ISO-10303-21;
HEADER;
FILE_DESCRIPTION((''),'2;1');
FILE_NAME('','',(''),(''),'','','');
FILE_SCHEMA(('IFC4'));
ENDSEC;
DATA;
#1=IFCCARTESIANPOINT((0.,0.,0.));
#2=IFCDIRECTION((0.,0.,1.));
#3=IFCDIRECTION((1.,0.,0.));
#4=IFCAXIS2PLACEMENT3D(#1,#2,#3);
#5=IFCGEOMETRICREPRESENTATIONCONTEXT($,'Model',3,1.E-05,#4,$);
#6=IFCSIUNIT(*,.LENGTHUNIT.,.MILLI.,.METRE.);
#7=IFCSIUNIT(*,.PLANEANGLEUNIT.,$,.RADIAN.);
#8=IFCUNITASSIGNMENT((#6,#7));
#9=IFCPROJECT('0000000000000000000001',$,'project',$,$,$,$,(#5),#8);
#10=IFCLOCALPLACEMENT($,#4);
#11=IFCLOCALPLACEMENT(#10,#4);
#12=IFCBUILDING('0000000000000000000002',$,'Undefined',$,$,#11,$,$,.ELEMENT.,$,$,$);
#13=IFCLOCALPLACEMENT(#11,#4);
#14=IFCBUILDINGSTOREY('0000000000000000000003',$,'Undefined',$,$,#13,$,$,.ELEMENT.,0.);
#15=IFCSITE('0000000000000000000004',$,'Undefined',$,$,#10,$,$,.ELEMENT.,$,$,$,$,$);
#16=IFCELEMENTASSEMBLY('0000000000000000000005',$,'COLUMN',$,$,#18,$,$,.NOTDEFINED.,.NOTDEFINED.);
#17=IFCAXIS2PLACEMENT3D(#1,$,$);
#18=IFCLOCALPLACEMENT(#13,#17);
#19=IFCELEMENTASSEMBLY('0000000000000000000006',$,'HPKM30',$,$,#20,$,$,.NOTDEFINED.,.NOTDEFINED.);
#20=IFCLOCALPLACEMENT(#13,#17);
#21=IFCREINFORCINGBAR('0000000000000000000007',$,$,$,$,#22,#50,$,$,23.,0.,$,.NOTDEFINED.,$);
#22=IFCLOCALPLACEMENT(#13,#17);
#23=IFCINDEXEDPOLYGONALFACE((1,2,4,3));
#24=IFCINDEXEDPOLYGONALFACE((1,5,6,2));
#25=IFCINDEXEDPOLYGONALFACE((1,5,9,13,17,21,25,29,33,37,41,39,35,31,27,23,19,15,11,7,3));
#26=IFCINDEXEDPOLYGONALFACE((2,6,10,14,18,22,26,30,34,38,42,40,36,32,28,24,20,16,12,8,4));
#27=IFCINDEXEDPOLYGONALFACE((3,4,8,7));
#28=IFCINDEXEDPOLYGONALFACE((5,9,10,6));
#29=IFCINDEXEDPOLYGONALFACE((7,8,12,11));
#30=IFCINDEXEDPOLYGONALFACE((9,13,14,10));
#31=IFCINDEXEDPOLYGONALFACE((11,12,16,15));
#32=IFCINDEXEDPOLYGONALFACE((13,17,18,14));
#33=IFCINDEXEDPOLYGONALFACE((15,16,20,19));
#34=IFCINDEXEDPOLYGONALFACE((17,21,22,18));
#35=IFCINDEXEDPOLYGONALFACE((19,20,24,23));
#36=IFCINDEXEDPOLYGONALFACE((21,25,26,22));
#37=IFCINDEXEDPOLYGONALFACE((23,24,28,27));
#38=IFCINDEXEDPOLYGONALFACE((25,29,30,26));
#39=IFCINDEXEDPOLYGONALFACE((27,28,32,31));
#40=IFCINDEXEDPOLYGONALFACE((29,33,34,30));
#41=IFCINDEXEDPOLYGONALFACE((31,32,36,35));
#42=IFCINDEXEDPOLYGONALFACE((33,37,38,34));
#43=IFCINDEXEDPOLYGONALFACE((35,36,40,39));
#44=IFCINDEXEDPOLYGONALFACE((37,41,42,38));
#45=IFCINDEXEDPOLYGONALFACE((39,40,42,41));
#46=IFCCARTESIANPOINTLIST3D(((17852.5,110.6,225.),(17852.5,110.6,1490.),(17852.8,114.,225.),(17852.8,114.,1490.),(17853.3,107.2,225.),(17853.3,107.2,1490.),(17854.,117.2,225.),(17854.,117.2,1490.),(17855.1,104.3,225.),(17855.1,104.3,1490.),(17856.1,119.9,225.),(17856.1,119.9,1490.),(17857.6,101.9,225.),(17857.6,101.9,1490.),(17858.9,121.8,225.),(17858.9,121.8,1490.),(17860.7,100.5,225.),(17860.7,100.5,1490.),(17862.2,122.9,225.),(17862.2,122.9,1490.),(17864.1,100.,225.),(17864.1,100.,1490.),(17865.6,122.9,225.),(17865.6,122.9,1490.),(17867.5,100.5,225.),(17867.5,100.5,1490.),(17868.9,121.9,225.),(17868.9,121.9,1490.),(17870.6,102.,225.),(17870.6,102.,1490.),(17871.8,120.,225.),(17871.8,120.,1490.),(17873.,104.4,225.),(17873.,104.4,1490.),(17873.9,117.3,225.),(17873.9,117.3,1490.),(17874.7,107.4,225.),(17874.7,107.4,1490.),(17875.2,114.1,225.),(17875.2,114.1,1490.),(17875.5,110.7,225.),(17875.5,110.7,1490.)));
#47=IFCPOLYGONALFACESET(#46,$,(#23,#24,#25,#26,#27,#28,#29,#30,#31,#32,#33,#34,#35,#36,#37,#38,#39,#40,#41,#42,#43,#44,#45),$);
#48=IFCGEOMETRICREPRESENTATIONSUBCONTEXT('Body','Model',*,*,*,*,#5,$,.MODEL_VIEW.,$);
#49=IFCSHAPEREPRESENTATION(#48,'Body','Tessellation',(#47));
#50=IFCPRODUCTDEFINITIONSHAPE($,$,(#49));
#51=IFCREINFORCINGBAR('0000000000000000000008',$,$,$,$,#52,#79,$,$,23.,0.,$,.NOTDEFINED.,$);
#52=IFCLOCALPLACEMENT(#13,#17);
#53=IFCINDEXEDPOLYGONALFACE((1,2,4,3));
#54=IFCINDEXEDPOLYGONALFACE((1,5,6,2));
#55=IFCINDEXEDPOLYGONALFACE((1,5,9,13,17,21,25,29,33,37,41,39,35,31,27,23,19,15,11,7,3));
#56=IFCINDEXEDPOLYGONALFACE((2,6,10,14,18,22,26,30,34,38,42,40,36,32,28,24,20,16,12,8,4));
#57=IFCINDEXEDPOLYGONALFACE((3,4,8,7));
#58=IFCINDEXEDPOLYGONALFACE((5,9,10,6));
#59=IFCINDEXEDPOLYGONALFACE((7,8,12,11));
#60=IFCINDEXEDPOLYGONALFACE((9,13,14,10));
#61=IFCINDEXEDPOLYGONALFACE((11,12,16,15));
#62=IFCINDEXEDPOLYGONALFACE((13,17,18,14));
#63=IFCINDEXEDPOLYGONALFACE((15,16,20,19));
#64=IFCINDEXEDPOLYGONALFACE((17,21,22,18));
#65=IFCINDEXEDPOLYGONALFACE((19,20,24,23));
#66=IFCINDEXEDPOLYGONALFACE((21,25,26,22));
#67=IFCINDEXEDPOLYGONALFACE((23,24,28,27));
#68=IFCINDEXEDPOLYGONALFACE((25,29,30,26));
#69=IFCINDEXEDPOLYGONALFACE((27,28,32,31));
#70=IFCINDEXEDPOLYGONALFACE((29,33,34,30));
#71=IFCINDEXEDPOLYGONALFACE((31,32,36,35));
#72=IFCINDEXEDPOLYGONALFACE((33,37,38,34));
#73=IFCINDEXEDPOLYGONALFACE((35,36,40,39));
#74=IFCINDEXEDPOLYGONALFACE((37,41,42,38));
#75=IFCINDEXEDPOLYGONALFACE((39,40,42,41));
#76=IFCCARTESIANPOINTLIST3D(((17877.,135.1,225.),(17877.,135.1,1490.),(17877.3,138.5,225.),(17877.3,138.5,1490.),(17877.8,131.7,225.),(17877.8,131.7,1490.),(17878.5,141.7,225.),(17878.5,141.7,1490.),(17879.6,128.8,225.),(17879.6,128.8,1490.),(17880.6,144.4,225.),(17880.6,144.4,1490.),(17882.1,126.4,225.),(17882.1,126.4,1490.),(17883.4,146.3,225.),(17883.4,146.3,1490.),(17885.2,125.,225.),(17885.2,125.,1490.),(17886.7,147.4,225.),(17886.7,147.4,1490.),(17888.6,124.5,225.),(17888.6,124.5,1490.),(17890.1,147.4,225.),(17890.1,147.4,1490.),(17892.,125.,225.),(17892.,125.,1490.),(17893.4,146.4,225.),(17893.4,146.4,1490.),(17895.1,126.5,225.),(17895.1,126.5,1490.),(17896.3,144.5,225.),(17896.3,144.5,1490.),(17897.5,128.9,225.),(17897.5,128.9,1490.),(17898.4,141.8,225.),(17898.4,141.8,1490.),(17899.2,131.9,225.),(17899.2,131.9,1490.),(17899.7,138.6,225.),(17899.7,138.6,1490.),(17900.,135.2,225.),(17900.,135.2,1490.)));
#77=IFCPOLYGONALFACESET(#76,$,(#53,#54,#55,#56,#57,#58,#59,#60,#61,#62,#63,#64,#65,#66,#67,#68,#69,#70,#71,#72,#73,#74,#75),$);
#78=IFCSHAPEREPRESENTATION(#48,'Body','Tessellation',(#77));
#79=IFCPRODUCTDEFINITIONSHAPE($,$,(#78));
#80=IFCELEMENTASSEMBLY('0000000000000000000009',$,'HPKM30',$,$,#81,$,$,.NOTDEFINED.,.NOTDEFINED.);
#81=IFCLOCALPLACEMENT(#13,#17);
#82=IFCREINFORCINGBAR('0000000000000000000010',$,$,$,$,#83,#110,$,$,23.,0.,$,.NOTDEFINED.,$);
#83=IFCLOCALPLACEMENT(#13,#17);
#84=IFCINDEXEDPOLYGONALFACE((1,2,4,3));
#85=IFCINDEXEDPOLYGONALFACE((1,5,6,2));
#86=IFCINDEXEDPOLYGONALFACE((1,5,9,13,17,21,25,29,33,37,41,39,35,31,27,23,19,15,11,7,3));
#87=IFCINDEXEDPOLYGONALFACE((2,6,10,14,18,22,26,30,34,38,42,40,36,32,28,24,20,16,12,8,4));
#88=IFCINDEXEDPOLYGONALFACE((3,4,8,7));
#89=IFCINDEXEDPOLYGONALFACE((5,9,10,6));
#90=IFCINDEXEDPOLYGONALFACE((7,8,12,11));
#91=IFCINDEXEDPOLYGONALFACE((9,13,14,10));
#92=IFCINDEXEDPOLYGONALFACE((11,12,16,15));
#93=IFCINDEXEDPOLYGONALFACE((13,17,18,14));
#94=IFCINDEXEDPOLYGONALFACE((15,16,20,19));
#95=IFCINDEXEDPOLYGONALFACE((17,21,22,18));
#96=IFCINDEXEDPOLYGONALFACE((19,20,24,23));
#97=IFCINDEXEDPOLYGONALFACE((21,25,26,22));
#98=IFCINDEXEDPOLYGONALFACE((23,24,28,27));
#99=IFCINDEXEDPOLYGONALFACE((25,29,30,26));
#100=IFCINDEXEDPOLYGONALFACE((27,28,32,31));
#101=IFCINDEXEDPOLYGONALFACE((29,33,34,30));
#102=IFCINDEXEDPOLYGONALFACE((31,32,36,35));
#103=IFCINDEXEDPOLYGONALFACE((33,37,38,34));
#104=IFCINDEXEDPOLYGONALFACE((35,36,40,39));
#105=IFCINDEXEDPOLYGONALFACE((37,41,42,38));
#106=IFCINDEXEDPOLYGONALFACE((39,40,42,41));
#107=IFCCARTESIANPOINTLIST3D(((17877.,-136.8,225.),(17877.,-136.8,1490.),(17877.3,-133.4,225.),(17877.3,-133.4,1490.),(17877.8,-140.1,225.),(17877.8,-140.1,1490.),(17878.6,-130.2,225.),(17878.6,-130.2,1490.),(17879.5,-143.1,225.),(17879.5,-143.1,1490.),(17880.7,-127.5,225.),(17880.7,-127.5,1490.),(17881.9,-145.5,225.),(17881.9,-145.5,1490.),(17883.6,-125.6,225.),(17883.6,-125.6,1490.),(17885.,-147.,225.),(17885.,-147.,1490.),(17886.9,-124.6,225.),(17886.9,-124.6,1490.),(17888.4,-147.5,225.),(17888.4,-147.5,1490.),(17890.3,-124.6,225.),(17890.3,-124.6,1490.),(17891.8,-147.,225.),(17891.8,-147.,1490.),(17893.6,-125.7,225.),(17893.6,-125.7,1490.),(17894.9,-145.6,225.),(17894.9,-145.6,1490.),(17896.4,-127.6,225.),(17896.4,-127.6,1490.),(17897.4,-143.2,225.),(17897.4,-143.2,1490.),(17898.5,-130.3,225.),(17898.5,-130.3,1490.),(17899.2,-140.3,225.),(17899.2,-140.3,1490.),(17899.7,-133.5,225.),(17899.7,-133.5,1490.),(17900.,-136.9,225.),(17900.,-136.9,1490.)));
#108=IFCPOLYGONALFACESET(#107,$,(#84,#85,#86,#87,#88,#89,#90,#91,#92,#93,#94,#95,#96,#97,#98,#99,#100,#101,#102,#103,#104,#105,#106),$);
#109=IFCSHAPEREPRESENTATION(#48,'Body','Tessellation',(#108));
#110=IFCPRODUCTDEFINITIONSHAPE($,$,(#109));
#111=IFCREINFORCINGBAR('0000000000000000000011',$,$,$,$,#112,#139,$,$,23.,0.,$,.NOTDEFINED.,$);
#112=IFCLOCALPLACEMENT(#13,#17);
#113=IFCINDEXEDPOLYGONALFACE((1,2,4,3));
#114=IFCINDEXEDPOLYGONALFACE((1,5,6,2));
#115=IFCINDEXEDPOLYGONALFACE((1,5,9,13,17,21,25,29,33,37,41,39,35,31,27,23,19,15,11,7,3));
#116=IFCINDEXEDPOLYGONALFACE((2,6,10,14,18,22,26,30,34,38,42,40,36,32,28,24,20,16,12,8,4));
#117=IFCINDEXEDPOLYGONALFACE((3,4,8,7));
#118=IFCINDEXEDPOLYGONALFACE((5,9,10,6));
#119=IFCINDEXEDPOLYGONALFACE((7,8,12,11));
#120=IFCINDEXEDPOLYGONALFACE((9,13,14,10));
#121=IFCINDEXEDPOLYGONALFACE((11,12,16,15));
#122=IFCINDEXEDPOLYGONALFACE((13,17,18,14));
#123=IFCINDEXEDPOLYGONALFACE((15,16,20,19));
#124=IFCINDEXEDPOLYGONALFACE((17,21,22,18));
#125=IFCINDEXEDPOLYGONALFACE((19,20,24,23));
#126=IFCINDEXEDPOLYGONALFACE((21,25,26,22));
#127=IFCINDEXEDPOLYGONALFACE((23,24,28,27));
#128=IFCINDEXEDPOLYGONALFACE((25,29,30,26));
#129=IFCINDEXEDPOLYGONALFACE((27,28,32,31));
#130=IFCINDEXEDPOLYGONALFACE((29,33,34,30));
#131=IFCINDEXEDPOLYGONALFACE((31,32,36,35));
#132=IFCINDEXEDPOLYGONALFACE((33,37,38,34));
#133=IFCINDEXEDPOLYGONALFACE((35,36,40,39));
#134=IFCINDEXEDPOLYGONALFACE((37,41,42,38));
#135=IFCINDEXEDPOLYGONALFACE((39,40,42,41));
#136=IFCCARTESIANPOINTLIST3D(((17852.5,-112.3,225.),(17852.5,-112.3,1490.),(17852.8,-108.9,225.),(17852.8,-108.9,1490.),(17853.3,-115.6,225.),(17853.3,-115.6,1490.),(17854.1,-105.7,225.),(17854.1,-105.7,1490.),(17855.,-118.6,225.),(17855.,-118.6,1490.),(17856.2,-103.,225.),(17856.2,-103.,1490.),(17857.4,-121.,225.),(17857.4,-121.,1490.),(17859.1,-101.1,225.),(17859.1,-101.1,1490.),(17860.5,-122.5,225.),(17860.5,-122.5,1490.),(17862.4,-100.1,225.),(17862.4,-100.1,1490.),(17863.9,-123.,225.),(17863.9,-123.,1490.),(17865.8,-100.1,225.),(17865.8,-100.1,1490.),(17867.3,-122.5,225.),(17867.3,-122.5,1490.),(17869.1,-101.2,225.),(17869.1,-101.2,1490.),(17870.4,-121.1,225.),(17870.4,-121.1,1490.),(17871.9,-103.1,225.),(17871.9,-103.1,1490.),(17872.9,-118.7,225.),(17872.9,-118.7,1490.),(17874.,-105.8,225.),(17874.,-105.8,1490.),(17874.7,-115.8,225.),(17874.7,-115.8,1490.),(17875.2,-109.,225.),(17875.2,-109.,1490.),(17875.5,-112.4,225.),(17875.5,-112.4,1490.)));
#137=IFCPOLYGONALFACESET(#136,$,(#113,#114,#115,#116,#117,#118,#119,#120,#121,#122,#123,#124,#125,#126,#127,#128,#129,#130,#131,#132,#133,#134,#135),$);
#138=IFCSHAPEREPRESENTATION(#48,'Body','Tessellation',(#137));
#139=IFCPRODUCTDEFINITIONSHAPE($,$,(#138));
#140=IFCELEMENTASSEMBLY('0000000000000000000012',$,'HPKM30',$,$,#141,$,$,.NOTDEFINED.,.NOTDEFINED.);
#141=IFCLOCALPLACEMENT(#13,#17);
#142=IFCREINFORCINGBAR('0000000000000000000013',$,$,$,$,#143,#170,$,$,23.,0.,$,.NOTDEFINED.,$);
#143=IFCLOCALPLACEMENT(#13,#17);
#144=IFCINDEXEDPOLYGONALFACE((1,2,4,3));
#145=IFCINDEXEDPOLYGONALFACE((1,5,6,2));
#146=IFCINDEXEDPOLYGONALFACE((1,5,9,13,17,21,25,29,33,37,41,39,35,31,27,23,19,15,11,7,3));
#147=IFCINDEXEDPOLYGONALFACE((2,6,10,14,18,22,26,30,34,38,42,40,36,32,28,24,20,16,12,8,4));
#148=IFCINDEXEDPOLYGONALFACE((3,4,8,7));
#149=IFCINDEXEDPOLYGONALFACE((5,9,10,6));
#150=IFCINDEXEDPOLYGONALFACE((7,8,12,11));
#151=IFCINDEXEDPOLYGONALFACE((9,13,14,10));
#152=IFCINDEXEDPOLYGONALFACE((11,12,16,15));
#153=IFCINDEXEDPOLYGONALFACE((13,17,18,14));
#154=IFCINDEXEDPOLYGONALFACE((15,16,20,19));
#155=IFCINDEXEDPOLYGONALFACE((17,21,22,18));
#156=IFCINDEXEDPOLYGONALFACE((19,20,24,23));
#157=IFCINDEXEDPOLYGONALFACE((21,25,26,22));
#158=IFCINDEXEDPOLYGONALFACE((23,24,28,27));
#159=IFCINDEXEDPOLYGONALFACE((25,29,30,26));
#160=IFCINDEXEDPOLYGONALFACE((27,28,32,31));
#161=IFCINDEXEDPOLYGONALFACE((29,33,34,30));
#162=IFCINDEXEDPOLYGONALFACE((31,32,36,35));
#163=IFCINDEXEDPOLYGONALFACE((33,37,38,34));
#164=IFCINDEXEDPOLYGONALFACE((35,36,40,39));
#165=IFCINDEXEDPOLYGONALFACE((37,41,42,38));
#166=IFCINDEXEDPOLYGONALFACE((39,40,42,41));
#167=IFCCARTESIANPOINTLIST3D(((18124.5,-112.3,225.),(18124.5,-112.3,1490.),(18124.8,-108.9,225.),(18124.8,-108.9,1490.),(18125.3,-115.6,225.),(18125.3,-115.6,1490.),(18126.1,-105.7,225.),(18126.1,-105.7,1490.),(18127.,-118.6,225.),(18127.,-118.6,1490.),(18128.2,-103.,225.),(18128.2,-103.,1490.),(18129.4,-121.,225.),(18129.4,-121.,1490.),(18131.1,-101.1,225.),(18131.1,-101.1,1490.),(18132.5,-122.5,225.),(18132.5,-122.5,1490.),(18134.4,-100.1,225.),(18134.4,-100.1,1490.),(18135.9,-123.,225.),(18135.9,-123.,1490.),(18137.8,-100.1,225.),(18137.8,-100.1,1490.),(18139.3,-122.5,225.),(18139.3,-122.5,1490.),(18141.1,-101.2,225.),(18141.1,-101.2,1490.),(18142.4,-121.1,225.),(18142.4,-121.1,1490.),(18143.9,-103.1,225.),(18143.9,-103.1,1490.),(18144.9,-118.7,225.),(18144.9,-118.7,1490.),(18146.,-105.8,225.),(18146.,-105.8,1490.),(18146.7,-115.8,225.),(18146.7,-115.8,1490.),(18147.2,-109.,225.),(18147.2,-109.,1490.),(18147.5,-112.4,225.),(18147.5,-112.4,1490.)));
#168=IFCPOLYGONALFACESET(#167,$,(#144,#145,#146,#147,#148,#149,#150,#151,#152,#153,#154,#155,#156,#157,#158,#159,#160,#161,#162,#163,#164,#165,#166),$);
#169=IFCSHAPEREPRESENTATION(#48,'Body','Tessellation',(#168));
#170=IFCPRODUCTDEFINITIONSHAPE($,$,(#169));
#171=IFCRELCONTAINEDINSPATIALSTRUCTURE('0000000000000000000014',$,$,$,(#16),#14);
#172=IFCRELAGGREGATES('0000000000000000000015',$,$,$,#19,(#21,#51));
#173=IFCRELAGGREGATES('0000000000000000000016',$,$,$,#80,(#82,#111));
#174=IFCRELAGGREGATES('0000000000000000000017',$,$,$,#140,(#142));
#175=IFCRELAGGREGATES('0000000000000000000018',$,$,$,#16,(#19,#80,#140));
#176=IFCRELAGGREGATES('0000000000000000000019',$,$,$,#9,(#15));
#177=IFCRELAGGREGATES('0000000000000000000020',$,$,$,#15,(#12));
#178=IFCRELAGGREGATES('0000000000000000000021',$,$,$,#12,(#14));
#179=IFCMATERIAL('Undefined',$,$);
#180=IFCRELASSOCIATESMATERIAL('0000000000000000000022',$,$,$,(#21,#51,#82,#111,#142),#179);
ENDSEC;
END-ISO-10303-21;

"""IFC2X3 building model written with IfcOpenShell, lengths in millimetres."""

from ifc_helpers import new_model, entity, si_unit, frame, origin_with_axes, place, context, subcontext, project, spatial, source, transform, mapped, material, element, aggregate, save


model = new_model("IFC2X3")

# Units and contexts
model_context = context("Model", 3, precision=1e-05, world=origin_with_axes())
body_context = subcontext(model_context, "Body", "Model", "MODEL_VIEW")
ifc_project = project(units=[si_unit("LENGTHUNIT", "METRE", prefix="MILLI"), si_unit("PLANEANGLEUNIT", "RADIAN")], contexts=[model_context])

# Site, building, storey
site_placement = place(None, origin_with_axes())
site = spatial("IfcSite", under=ifc_project, at=site_placement, Name="Undefined", CompositionType="ELEMENT")
building_placement = place(site_placement, origin_with_axes())
building = spatial("IfcBuilding", under=site, at=building_placement, Name="Undefined", CompositionType="ELEMENT")
storey_placement = place(building_placement, origin_with_axes())
storey = spatial("IfcBuildingStorey", under=building, at=storey_placement, Name="Undefined", CompositionType="ELEMENT", Elevation=0.0)

# Shared definitions
ifc_material_1 = material(Name="Undefined")

# Element assemblies, reinforcing bars
assembly_1_placement = place(storey_placement, origin_with_axes())
assembly_1 = element("IfcElementAssembly", 1, at=assembly_1_placement, inside=storey, Name="COLUMN", AssemblyPlace="NOTDEFINED", PredefinedType="NOTDEFINED")
assembly_2_placement = place(assembly_1_placement, origin_with_axes())
assembly_2 = element("IfcElementAssembly", 2, at=assembly_2_placement, Name="HPKM30", AssemblyPlace="NOTDEFINED", PredefinedType="NOTDEFINED")
shared_shape_1 = source(origin_with_axes(), body_context, "Body", "AdvancedSweptSolid", [
    entity("IfcSweptDiskSolid", entity("IfcTrimmedCurve", entity("IfcLine", entity("IfcCartesianPoint", [0.0, 0.0, 0.0]), entity("IfcVector", entity("IfcDirection", [1.0, 0.0, 0.0]), 1.0)), [entity("IfcParameterValue", 0.0)], [entity("IfcParameterValue", 1265.0)], True, "PARAMETER"), 11.5, None, 0.0, 1265.0),
])
reinforcing_bar_1_placement = place(assembly_2_placement, frame((17864.0, 111.5, 225.0), z_axis=(0.007839, -0.999969, 0.0), x_axis=(0.0, 0.0, 1.0)))
reinforcing_bar_1 = element("IfcReinforcingBar", 3, at=reinforcing_bar_1_placement, material=ifc_material_1, BarRole="NOTDEFINED", CrossSectionArea=0.0, NominalDiameter=23.0, context=body_context, shape_type="MappedRepresentation", body=[
    mapped(shared_shape_1, transform((0.0, 0.0, 0.0))),
])
shared_shape_2 = source(origin_with_axes(), body_context, "Body", "AdvancedSweptSolid", [
    entity("IfcSweptDiskSolid", entity("IfcTrimmedCurve", entity("IfcLine", entity("IfcCartesianPoint", [0.0, 0.0, 0.0]), entity("IfcVector", entity("IfcDirection", [1.0, 0.0, 0.0]), 1.0)), [entity("IfcParameterValue", 0.0)], [entity("IfcParameterValue", 1265.0)], True, "PARAMETER"), 11.5, None, 0.0, 1265.0),
])
reinforcing_bar_2_placement = place(assembly_2_placement, frame((17888.5, 136.0, 225.0), z_axis=(0.007839, -0.999969, 0.0), x_axis=(0.0, 0.0, 1.0)))
reinforcing_bar_2 = element("IfcReinforcingBar", 4, at=reinforcing_bar_2_placement, material=ifc_material_1, BarRole="NOTDEFINED", CrossSectionArea=0.0, NominalDiameter=23.0, context=body_context, shape_type="MappedRepresentation", body=[
    mapped(shared_shape_2, transform((0.0, 0.0, 0.0))),
])
aggregate(assembly_2, [reinforcing_bar_1, reinforcing_bar_2])
assembly_3_placement = place(assembly_1_placement, origin_with_axes())
assembly_3 = element("IfcElementAssembly", 5, at=assembly_3_placement, Name="HPKM30", AssemblyPlace="NOTDEFINED", PredefinedType="NOTDEFINED")
shared_shape_3 = source(origin_with_axes(), body_context, "Body", "AdvancedSweptSolid", [
    entity("IfcSweptDiskSolid", entity("IfcTrimmedCurve", entity("IfcLine", entity("IfcCartesianPoint", [0.0, 0.0, 0.0]), entity("IfcVector", entity("IfcDirection", [1.0, 0.0, 0.0]), 1.0)), [entity("IfcParameterValue", 0.0)], [entity("IfcParameterValue", 1265.0)], True, "PARAMETER"), 11.5, None, 0.0, 1265.0),
])
reinforcing_bar_3_placement = place(assembly_3_placement, frame((17888.5, -136.0, 225.0), z_axis=(-0.007839, -0.999969, 0.0), x_axis=(0.0, 0.0, 1.0)))
reinforcing_bar_3 = element("IfcReinforcingBar", 6, at=reinforcing_bar_3_placement, material=ifc_material_1, BarRole="NOTDEFINED", CrossSectionArea=0.0, NominalDiameter=23.0, context=body_context, shape_type="MappedRepresentation", body=[
    mapped(shared_shape_3, transform((0.0, 0.0, 0.0))),
])
shared_shape_4 = source(origin_with_axes(), body_context, "Body", "AdvancedSweptSolid", [
    entity("IfcSweptDiskSolid", entity("IfcTrimmedCurve", entity("IfcLine", entity("IfcCartesianPoint", [0.0, 0.0, 0.0]), entity("IfcVector", entity("IfcDirection", [1.0, 0.0, 0.0]), 1.0)), [entity("IfcParameterValue", 0.0)], [entity("IfcParameterValue", 1265.0)], True, "PARAMETER"), 11.5, None, 0.0, 1265.0),
])
reinforcing_bar_4_placement = place(assembly_3_placement, frame((17864.0, -111.5, 225.0), z_axis=(-0.007839, -0.999969, 0.0), x_axis=(0.0, 0.0, 1.0)))
reinforcing_bar_4 = element("IfcReinforcingBar", 7, at=reinforcing_bar_4_placement, material=ifc_material_1, BarRole="NOTDEFINED", CrossSectionArea=0.0, NominalDiameter=23.0, context=body_context, shape_type="MappedRepresentation", body=[
    mapped(shared_shape_4, transform((0.0, 0.0, 0.0))),
])
aggregate(assembly_3, [reinforcing_bar_3, reinforcing_bar_4])
assembly_4_placement = place(assembly_1_placement, origin_with_axes())
assembly_4 = element("IfcElementAssembly", 8, at=assembly_4_placement, Name="HPKM30", AssemblyPlace="NOTDEFINED", PredefinedType="NOTDEFINED")
shared_shape_5 = source(origin_with_axes(), body_context, "Body", "AdvancedSweptSolid", [
    entity("IfcSweptDiskSolid", entity("IfcTrimmedCurve", entity("IfcLine", entity("IfcCartesianPoint", [0.0, 0.0, 0.0]), entity("IfcVector", entity("IfcDirection", [1.0, 0.0, 0.0]), 1.0)), [entity("IfcParameterValue", 0.0)], [entity("IfcParameterValue", 1265.0)], True, "PARAMETER"), 11.5, None, 0.0, 1265.0),
])
reinforcing_bar_5_placement = place(assembly_4_placement, frame((18136.0, -111.5, 225.0), z_axis=(-0.007718, -0.99997, 0.0), x_axis=(0.0, 0.0, 1.0)))
reinforcing_bar_5 = element("IfcReinforcingBar", 9, at=reinforcing_bar_5_placement, material=ifc_material_1, BarRole="NOTDEFINED", CrossSectionArea=0.0, NominalDiameter=23.0, context=body_context, shape_type="MappedRepresentation", body=[
    mapped(shared_shape_5, transform((0.0, 0.0, 0.0))),
])
aggregate(assembly_4, [reinforcing_bar_5])
aggregate(assembly_1, [assembly_2, assembly_3, assembly_4])

save(model, "model.ifc")
